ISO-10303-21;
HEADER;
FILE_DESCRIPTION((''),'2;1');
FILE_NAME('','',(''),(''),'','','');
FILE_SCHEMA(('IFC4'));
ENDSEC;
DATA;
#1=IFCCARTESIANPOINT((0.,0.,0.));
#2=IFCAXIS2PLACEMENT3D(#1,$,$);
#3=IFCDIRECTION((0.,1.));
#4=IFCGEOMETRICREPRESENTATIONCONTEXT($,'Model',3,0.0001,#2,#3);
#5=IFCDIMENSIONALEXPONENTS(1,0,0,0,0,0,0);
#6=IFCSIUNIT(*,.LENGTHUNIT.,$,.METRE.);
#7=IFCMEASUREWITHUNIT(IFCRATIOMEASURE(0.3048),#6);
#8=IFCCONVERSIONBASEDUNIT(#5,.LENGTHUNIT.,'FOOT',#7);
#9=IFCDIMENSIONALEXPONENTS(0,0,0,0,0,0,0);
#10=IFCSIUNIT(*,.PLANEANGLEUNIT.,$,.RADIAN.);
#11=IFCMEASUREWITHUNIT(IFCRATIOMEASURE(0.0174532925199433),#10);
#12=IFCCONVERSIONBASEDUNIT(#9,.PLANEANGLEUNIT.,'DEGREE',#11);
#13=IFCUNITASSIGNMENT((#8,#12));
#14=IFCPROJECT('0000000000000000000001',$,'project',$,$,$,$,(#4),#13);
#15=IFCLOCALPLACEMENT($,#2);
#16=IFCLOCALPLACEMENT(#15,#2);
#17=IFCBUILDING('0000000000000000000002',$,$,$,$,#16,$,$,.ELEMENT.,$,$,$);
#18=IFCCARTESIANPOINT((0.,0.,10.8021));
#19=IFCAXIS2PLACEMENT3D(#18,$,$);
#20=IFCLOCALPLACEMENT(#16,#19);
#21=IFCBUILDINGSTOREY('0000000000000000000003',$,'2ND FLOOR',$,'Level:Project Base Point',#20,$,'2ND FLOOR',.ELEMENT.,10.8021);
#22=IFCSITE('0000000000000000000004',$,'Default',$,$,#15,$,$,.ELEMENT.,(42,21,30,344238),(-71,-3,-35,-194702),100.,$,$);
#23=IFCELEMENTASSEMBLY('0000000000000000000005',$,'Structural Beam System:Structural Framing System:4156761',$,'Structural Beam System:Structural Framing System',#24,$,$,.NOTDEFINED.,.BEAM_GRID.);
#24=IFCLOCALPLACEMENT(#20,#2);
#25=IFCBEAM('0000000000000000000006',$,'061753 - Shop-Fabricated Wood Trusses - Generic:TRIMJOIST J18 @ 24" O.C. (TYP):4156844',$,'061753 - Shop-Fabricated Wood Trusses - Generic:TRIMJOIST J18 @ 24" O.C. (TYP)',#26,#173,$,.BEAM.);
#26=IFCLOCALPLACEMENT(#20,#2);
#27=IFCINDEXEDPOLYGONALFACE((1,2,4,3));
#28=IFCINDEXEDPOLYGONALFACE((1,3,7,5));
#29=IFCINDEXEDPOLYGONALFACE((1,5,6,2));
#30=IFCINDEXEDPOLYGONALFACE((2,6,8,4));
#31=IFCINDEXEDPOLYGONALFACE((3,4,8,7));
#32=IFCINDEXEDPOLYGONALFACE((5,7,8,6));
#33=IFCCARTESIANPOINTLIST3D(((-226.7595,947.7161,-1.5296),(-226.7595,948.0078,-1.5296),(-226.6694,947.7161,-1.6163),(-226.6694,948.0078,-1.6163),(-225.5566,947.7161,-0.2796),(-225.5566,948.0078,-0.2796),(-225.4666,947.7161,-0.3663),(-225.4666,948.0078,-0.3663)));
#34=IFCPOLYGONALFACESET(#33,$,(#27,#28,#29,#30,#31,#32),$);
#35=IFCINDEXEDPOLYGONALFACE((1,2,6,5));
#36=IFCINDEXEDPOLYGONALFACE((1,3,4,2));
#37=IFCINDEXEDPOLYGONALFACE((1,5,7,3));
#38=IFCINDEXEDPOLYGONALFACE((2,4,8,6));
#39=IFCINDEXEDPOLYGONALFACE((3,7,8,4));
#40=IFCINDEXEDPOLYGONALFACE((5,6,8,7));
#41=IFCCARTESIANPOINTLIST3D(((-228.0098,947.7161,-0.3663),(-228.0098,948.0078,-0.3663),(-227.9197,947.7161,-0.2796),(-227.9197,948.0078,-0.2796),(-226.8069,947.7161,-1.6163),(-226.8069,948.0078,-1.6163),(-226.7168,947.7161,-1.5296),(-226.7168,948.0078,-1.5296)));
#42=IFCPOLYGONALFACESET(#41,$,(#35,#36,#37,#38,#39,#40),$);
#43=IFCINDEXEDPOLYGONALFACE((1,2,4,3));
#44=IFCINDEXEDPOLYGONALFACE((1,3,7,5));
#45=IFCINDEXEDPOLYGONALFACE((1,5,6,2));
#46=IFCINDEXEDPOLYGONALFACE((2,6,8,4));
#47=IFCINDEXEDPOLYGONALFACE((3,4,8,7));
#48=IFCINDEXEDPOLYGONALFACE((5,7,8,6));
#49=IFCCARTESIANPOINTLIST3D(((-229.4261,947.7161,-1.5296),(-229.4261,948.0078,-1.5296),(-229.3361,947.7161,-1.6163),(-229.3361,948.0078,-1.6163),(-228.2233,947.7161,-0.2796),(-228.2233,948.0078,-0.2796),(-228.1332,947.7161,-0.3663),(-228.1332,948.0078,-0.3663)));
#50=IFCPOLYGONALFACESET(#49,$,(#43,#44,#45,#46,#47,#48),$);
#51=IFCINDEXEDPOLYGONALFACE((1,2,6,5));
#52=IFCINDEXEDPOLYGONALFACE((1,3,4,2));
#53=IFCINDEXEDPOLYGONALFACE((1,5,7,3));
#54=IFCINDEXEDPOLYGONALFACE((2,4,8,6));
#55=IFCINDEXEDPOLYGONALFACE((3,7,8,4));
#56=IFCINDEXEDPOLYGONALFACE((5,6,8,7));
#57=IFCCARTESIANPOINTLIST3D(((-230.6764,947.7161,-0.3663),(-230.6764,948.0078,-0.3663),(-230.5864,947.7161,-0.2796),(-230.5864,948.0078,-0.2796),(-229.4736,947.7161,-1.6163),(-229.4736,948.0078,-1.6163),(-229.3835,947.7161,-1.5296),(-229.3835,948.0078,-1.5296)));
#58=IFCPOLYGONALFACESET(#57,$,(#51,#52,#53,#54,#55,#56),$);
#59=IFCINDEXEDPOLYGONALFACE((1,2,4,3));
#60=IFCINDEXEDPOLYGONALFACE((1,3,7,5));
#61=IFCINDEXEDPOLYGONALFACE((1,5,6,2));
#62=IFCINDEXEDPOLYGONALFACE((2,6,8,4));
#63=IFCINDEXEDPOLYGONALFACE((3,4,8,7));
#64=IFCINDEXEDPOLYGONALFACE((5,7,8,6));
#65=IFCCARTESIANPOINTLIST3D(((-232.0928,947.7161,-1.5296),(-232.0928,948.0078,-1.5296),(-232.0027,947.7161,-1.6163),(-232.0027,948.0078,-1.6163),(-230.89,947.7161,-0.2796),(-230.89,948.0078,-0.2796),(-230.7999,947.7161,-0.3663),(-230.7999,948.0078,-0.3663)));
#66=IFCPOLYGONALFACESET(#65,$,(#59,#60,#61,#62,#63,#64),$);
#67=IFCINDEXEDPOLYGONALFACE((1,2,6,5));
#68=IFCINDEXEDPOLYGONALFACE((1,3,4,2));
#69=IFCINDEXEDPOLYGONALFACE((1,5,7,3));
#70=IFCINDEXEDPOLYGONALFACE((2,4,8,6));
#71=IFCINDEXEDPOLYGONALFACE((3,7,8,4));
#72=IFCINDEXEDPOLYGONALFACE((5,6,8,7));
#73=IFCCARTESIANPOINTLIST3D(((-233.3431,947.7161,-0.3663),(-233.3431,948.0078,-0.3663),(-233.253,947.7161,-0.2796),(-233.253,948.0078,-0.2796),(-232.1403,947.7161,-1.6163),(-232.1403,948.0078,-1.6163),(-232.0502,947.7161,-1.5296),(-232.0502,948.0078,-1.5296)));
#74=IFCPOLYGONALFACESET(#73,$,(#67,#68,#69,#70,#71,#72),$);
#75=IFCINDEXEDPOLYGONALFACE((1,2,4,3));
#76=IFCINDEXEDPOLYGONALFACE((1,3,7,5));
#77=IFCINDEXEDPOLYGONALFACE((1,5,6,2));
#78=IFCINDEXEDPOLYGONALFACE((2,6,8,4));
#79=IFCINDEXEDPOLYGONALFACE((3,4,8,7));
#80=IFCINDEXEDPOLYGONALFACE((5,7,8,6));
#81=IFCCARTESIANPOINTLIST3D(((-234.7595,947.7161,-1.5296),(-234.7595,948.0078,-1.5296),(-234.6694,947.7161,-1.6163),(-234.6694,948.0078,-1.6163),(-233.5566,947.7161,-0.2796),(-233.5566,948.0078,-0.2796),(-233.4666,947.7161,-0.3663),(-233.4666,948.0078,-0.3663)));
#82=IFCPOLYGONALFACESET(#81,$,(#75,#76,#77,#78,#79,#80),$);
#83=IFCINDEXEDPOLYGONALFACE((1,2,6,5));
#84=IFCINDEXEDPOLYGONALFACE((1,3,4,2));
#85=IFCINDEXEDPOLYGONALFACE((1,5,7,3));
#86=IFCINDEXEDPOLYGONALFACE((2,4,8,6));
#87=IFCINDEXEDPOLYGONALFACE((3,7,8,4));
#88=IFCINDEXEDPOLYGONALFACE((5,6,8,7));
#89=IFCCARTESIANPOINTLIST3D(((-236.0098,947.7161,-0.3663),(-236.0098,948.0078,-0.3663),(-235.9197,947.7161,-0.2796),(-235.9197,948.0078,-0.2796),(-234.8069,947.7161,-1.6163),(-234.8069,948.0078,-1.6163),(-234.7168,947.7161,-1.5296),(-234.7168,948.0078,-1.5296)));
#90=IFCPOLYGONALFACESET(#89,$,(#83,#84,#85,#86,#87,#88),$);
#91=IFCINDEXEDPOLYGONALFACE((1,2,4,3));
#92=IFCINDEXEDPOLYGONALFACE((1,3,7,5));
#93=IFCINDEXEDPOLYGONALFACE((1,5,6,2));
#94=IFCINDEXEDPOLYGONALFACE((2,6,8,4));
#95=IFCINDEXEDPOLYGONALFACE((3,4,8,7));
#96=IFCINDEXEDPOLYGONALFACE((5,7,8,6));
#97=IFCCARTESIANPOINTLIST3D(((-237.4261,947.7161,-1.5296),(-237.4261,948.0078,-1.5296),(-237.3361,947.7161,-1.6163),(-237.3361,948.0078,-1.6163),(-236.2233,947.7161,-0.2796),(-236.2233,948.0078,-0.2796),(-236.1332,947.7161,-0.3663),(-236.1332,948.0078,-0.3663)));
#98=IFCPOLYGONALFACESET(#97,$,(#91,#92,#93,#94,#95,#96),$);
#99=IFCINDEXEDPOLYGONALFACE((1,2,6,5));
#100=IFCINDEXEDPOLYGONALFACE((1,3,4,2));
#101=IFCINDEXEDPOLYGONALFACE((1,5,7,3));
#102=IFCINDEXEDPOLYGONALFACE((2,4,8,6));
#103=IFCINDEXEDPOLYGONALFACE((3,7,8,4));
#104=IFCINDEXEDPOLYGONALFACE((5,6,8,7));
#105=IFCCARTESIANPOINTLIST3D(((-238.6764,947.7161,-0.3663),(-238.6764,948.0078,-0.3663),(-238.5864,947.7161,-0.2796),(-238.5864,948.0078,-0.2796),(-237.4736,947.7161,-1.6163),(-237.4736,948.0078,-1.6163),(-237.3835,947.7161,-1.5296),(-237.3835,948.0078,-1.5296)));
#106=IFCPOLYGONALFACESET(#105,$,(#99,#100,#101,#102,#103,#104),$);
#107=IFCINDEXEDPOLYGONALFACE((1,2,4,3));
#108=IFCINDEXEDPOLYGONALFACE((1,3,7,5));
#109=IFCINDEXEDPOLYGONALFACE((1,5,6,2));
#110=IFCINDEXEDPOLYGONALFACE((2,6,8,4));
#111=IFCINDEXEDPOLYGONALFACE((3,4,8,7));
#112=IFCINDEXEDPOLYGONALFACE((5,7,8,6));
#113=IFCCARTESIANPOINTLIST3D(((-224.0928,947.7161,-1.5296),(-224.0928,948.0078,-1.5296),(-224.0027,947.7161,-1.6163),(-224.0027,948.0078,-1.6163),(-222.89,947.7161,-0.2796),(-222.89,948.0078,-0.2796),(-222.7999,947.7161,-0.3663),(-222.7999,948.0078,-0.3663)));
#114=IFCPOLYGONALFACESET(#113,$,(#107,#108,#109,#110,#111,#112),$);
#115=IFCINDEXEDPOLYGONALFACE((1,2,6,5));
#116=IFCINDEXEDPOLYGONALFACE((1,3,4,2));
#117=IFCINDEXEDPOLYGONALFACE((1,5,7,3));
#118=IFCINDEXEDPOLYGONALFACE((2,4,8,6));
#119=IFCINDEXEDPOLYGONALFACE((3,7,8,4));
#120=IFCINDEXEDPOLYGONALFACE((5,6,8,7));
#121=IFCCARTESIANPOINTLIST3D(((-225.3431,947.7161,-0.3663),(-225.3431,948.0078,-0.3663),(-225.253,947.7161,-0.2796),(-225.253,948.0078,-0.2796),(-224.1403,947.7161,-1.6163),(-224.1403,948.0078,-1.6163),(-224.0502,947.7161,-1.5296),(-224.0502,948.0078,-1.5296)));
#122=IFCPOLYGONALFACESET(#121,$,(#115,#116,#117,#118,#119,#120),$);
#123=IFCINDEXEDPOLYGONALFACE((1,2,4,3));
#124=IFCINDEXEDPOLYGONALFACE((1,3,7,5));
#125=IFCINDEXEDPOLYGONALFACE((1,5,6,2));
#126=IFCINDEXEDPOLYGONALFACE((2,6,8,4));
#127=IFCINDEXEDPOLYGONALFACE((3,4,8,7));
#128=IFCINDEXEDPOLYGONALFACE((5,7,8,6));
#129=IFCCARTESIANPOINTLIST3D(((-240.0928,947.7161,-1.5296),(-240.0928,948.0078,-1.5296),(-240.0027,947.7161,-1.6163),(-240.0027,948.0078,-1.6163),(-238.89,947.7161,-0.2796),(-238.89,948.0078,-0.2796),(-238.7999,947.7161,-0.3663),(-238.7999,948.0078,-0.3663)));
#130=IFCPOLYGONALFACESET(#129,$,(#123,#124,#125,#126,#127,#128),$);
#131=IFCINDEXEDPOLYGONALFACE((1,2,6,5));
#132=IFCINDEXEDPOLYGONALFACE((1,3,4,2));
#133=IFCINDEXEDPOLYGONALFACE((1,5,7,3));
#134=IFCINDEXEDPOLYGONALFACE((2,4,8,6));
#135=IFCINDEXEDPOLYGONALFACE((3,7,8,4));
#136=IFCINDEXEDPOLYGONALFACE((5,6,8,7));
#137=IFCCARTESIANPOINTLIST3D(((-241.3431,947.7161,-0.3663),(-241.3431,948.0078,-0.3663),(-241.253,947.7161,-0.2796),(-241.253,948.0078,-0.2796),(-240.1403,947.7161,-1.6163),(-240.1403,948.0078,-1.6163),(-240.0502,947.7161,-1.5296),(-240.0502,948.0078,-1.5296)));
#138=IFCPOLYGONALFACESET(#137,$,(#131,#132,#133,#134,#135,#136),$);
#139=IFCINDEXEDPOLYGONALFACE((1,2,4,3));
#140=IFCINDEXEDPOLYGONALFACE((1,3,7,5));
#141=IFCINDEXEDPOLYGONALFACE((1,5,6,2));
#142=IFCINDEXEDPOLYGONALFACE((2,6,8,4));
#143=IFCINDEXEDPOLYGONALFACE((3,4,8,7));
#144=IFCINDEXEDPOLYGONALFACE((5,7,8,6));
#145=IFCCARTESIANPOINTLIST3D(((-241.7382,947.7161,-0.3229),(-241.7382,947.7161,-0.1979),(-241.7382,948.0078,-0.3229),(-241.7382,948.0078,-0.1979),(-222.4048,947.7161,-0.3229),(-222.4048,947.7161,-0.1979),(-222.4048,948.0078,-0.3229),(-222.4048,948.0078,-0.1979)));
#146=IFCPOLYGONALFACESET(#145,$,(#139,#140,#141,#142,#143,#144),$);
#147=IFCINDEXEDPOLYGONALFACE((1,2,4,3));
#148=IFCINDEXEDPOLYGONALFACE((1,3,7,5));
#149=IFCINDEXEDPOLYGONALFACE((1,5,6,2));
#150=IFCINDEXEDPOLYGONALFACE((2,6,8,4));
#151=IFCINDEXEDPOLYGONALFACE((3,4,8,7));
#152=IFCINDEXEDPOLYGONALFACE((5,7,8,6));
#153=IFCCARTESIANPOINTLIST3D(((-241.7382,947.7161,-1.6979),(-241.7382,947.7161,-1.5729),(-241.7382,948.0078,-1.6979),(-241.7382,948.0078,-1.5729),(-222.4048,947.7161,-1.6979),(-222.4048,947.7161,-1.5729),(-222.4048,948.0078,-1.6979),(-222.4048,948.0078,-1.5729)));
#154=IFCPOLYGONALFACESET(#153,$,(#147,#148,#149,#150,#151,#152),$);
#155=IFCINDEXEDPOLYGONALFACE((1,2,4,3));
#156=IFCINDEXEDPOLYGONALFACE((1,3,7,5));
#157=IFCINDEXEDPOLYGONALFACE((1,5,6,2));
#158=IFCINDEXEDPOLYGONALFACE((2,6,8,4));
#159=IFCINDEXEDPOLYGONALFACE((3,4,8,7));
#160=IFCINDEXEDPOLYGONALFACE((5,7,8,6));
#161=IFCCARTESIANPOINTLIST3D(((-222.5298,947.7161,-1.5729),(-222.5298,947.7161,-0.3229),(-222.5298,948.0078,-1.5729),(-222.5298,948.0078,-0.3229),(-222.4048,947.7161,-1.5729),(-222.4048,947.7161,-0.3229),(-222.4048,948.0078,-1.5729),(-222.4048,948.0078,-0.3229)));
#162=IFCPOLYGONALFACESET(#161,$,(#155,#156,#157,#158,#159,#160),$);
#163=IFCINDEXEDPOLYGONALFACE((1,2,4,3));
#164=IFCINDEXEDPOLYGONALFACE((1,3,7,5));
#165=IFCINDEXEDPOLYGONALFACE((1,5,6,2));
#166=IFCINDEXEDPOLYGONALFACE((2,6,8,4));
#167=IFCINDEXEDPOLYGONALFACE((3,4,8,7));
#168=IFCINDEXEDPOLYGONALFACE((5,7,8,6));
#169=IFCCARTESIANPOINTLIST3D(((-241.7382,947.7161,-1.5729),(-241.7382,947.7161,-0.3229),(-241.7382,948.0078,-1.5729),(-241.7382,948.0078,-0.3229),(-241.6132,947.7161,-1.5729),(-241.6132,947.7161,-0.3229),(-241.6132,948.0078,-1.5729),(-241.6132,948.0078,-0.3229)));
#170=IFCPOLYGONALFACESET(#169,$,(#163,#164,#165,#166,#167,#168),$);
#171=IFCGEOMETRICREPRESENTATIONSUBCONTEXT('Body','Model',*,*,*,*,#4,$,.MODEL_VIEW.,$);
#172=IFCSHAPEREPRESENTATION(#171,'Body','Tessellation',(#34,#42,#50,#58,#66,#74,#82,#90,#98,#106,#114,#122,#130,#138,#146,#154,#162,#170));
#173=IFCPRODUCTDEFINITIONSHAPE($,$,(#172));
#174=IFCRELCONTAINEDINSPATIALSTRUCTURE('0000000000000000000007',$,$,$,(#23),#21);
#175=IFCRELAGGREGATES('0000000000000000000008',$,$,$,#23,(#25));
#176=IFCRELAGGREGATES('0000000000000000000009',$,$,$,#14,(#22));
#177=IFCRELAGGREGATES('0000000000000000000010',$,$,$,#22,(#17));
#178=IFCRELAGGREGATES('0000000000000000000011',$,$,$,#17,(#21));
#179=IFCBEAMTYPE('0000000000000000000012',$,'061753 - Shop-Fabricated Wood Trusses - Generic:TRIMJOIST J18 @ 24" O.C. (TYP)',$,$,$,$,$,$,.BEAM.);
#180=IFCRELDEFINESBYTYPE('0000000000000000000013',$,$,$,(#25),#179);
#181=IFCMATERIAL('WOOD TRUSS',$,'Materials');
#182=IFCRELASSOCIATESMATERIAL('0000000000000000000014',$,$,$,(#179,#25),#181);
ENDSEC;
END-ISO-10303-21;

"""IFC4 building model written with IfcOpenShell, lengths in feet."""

from ifc_helpers import new_model, entity, si_unit, converted_unit, direction, frame, frame_2d, origin, origin_2d_with_axis, place, context, subcontext, project, spatial, rectangle, extrude, source, transform, mapped, material, material_profile, profile_set, profile_usage, type_object, type_shapes, element, aggregate, save


model = new_model("IFC4")

# Units and contexts
model_context = context("Model", 3, precision=0.0001, world=origin(), true_north=direction((0.0, 1.0)))
body_context = subcontext(model_context, "Body", "Model", "MODEL_VIEW")
ifc_project = project(units=[converted_unit("LENGTHUNIT", "FOOT", entity("IfcRatioMeasure", 0.3048), si_unit("LENGTHUNIT", "METRE"), dimensions=[1, 0, 0, 0, 0, 0, 0]), converted_unit("PLANEANGLEUNIT", "DEGREE", entity("IfcRatioMeasure", 0.0174532925199433), si_unit("PLANEANGLEUNIT", "RADIAN"), dimensions=[0, 0, 0, 0, 0, 0, 0])], contexts=[model_context])

# Site, building, storey
site_placement = place(None, origin())
site = spatial("IfcSite", under=ifc_project, at=site_placement, Name="Default", CompositionType="ELEMENT", RefLatitude=(42, 21, 30, 344238), RefLongitude=(-71, -3, -35, -194702), RefElevation=100.0)
building_placement = place(site_placement, origin())
building = spatial("IfcBuilding", under=site, at=building_placement, CompositionType="ELEMENT")
storey_placement = place(building_placement, frame((0.0, 0.0, 10.8021)))
storey = spatial("IfcBuildingStorey", under=building, at=storey_placement, Name="2ND FLOOR", ObjectType="Level:Project Base Point", LongName="2ND FLOOR", CompositionType="ELEMENT", Elevation=10.8021)

# Element assembly, beam
assembly_1_placement = place(storey_placement, origin())
assembly_1 = element("IfcElementAssembly", 1, at=assembly_1_placement, inside=storey, Name="Structural Beam System:Structural Framing System:4156761", ObjectType="Structural Beam System:Structural Framing System", AssemblyPlace="NOTDEFINED", PredefinedType="BEAM_GRID")
ifc_material_1 = material(Name="WOOD TRUSS", Category="Materials")
ifc_material_profile_1 = material_profile(ifc_material_1, rectangle(XDim=1.7347, YDim=0.125, at=frame_2d((0.0, 0.0), x_axis=(1.0, 0.0))), Name="TRIMJOIST J18 @ 24\" O.C. (TYP)")
ifc_material_profile_2 = material_profile(ifc_material_1, rectangle(XDim=1.7347, YDim=0.125, at=frame_2d((0.0, 0.0), x_axis=(1.0, 0.0))), Name="TRIMJOIST J18 @ 24\" O.C. (TYP)")
ifc_material_profile_3 = material_profile(ifc_material_1, rectangle(XDim=1.7347, YDim=0.125, at=frame_2d((0.0, 0.0), x_axis=(1.0, 0.0))), Name="TRIMJOIST J18 @ 24\" O.C. (TYP)")
ifc_material_profile_4 = material_profile(ifc_material_1, rectangle(XDim=1.7347, YDim=0.125, at=frame_2d((0.0, 0.0), x_axis=(1.0, 0.0))), Name="TRIMJOIST J18 @ 24\" O.C. (TYP)")
ifc_material_profile_5 = material_profile(ifc_material_1, rectangle(XDim=1.7347, YDim=0.125, at=frame_2d((0.0, 0.0), x_axis=(1.0, 0.0))), Name="TRIMJOIST J18 @ 24\" O.C. (TYP)")
ifc_material_profile_6 = material_profile(ifc_material_1, rectangle(XDim=1.7347, YDim=0.125, at=frame_2d((0.0, 0.0), x_axis=(1.0, 0.0))), Name="TRIMJOIST J18 @ 24\" O.C. (TYP)")
ifc_material_profile_7 = material_profile(ifc_material_1, rectangle(XDim=1.7347, YDim=0.125, at=frame_2d((0.0, 0.0), x_axis=(1.0, 0.0))), Name="TRIMJOIST J18 @ 24\" O.C. (TYP)")
ifc_material_profile_8 = material_profile(ifc_material_1, rectangle(XDim=1.7347, YDim=0.125, at=frame_2d((0.0, 0.0), x_axis=(1.0, 0.0))), Name="TRIMJOIST J18 @ 24\" O.C. (TYP)")
ifc_material_profile_9 = material_profile(ifc_material_1, rectangle(XDim=1.7347, YDim=0.125, at=frame_2d((0.0, 0.0), x_axis=(1.0, 0.0))), Name="TRIMJOIST J18 @ 24\" O.C. (TYP)")
ifc_material_profile_10 = material_profile(ifc_material_1, rectangle(XDim=1.7347, YDim=0.125, at=origin_2d_with_axis()), Name="TRIMJOIST J18 @ 24\" O.C. (TYP)")
ifc_material_profile_11 = material_profile(ifc_material_1, rectangle(XDim=0.125, YDim=0.2917, at=origin_2d_with_axis()), Name="TRIMJOIST J18 @ 24\" O.C. (TYP)")
ifc_material_profile_12 = material_profile(ifc_material_1, rectangle(XDim=0.125, YDim=0.2917, at=origin_2d_with_axis()), Name="TRIMJOIST J18 @ 24\" O.C. (TYP)")
ifc_material_profile_13 = material_profile(ifc_material_1, rectangle(XDim=1.25, YDim=0.2917, at=origin_2d_with_axis()), Name="TRIMJOIST J18 @ 24\" O.C. (TYP)")
ifc_material_profile_14 = material_profile(ifc_material_1, rectangle(XDim=1.25, YDim=0.2917, at=origin_2d_with_axis()), Name="TRIMJOIST J18 @ 24\" O.C. (TYP)")
ifc_profile_set_1 = profile_set([ifc_material_profile_1, ifc_material_profile_2, ifc_material_profile_3, ifc_material_profile_4, ifc_material_profile_5, ifc_material_profile_6, ifc_material_profile_7, ifc_material_profile_8, ifc_material_profile_9, ifc_material_profile_10, ifc_material_profile_11, ifc_material_profile_12, ifc_material_profile_13, ifc_material_profile_14], Name="TRIMJOIST J18 @ 24\" O.C. (TYP)")
beam_type_1 = type_object("IfcBeamType", Name="061753 - Shop-Fabricated Wood Trusses - Generic:TRIMJOIST J18 @ 24\" O.C. (TYP)", PredefinedType="BEAM", material=ifc_profile_set_1)
shared_shape_1 = source(origin(), body_context, "Body", "SweptSolid", [
    extrude(rectangle(XDim=1.7347, YDim=0.125, at=frame_2d((0.0, 0.0), x_axis=(1.0, 0.0))), frame((5.9585, -0.1458, 0.0), z_axis=(0.0, 1.0, 0.0), x_axis=(0.693383, 0.0, 0.720569)), (0.0, 0.0, 1.0), 0.2917),
    extrude(rectangle(XDim=1.7347, YDim=0.125, at=origin_2d_with_axis()), frame((4.7082, -0.1458, 0.0), z_axis=(0.0, 1.0, 0.0), x_axis=(0.693383, 0.0, -0.720569)), (0.0, 0.0, 1.0), 0.2917),
    extrude(rectangle(XDim=1.7347, YDim=0.125, at=frame_2d((0.0, 0.0), x_axis=(1.0, 0.0))), frame((3.2918, -0.1458, 0.0), z_axis=(0.0, 1.0, 0.0), x_axis=(0.693383, 0.0, 0.720569)), (0.0, 0.0, 1.0), 0.2917),
    extrude(rectangle(XDim=1.7347, YDim=0.125, at=frame_2d((0.0, 0.0), x_axis=(1.0, 0.0))), frame((2.0415, -0.1458, 0.0), z_axis=(0.0, 1.0, 0.0), x_axis=(0.693383, 0.0, -0.720569)), (0.0, 0.0, 1.0), 0.2917),
    extrude(rectangle(XDim=1.7347, YDim=0.125, at=frame_2d((0.0, 0.0), x_axis=(1.0, 0.0))), frame((0.6251, -0.1458, 0.0), z_axis=(0.0, 1.0, 0.0), x_axis=(0.693383, 0.0, 0.720569)), (0.0, 0.0, 1.0), 0.2917),
    extrude(rectangle(XDim=1.7347, YDim=0.125, at=frame_2d((0.0, 0.0), x_axis=(1.0, 0.0))), frame((-0.6251, -0.1458, 0.0), z_axis=(0.0, 1.0, 0.0), x_axis=(0.693383, 0.0, -0.720569)), (0.0, 0.0, 1.0), 0.2917),
    extrude(rectangle(XDim=1.7347, YDim=0.125, at=frame_2d((0.0, 0.0), x_axis=(1.0, 0.0))), frame((-2.0415, -0.1458, 0.0), z_axis=(0.0, 1.0, 0.0), x_axis=(0.693383, 0.0, 0.720569)), (0.0, 0.0, 1.0), 0.2917),
    extrude(rectangle(XDim=1.7347, YDim=0.125, at=origin_2d_with_axis()), frame((-3.2918, -0.1458, 0.0), z_axis=(0.0, 1.0, 0.0), x_axis=(0.693383, 0.0, -0.720569)), (0.0, 0.0, 1.0), 0.2917),
    extrude(rectangle(XDim=1.7347, YDim=0.125, at=frame_2d((0.0, 0.0), x_axis=(1.0, 0.0))), frame((-4.7082, -0.1458, 0.0), z_axis=(0.0, 1.0, 0.0), x_axis=(0.693383, 0.0, 0.720569)), (0.0, 0.0, 1.0), 0.2917),
    extrude(rectangle(XDim=1.7347, YDim=0.125, at=frame_2d((0.0, 0.0), x_axis=(1.0, 0.0))), frame((-5.9585, -0.1458, 0.0), z_axis=(0.0, 1.0, 0.0), x_axis=(0.693383, 0.0, -0.720569)), (0.0, 0.0, 1.0), 0.2917),
    extrude(rectangle(XDim=1.7347, YDim=0.125, at=frame_2d((0.0, 0.0), x_axis=(1.0, 0.0))), frame((8.6251, -0.1458, 0.0), z_axis=(0.0, 1.0, 0.0), x_axis=(0.693383, 0.0, 0.720569)), (0.0, 0.0, 1.0), 0.2917),
    extrude(rectangle(XDim=1.7347, YDim=0.125, at=origin_2d_with_axis()), frame((7.3749, -0.1458, 0.0), z_axis=(0.0, 1.0, 0.0), x_axis=(0.693383, 0.0, -0.720569)), (0.0, 0.0, 1.0), 0.2917),
    extrude(rectangle(XDim=1.7347, YDim=0.125, at=frame_2d((0.0, 0.0), x_axis=(1.0, 0.0))), frame((-7.3749, -0.1458, 0.0), z_axis=(0.0, 1.0, 0.0), x_axis=(0.693383, 0.0, 0.720569)), (0.0, 0.0, 1.0), 0.2917),
    extrude(rectangle(XDim=1.7347, YDim=0.125, at=origin_2d_with_axis()), frame((-8.6251, -0.1458, 0.0), z_axis=(0.0, 1.0, 0.0), x_axis=(0.693383, 0.0, -0.720569)), (0.0, 0.0, 1.0), 0.2917),
    extrude(rectangle(XDim=0.125, YDim=0.2917, at=origin_2d_with_axis()), frame((-9.6667, 0.0, 0.6875), z_axis=(1.0, 0.0, 0.0), x_axis=(0.0, 0.0, -1.0)), (0.0, 0.0, 1.0), 19.3333),
    extrude(rectangle(XDim=0.125, YDim=0.2917, at=origin_2d_with_axis()), frame((-9.6667, 0.0, -0.6875), z_axis=(1.0, 0.0, 0.0), x_axis=(0.0, 0.0, -1.0)), (0.0, 0.0, 1.0), 19.3333),
    extrude(rectangle(XDim=1.25, YDim=0.2917, at=origin_2d_with_axis()), frame((9.5417, 0.0, 0.0), z_axis=(1.0, 0.0, 0.0), x_axis=(0.0, 0.0, -1.0)), (0.0, 0.0, 1.0), 0.125),
    extrude(rectangle(XDim=1.25, YDim=0.2917, at=origin_2d_with_axis()), frame((-9.6667, 0.0, 0.0), z_axis=(1.0, 0.0, 0.0), x_axis=(0.0, 0.0, -1.0)), (0.0, 0.0, 1.0), 0.125),
])
type_shapes(beam_type_1, [shared_shape_1])
ifc_profile_usage_1 = profile_usage(ifc_profile_set_1, cardinal=8)
beam_1_placement = place(assembly_1_placement, frame((-232.0715, 947.8619, -0.9479)))
beam_1 = element("IfcBeam", 2, at=beam_1_placement, type_object=beam_type_1, material=ifc_profile_usage_1, Name="061753 - Shop-Fabricated Wood Trusses - Generic:TRIMJOIST J18 @ 24\" O.C. (TYP):4156844", ObjectType="061753 - Shop-Fabricated Wood Trusses - Generic:TRIMJOIST J18 @ 24\" O.C. (TYP)", PredefinedType="BEAM", context=body_context, shape_type="MappedRepresentation", body=[
    mapped(shared_shape_1, transform((0.0, 0.0, 0.0), scale=1.0)),
])
aggregate(assembly_1, [beam_1])

save(model, "model.ifc")
